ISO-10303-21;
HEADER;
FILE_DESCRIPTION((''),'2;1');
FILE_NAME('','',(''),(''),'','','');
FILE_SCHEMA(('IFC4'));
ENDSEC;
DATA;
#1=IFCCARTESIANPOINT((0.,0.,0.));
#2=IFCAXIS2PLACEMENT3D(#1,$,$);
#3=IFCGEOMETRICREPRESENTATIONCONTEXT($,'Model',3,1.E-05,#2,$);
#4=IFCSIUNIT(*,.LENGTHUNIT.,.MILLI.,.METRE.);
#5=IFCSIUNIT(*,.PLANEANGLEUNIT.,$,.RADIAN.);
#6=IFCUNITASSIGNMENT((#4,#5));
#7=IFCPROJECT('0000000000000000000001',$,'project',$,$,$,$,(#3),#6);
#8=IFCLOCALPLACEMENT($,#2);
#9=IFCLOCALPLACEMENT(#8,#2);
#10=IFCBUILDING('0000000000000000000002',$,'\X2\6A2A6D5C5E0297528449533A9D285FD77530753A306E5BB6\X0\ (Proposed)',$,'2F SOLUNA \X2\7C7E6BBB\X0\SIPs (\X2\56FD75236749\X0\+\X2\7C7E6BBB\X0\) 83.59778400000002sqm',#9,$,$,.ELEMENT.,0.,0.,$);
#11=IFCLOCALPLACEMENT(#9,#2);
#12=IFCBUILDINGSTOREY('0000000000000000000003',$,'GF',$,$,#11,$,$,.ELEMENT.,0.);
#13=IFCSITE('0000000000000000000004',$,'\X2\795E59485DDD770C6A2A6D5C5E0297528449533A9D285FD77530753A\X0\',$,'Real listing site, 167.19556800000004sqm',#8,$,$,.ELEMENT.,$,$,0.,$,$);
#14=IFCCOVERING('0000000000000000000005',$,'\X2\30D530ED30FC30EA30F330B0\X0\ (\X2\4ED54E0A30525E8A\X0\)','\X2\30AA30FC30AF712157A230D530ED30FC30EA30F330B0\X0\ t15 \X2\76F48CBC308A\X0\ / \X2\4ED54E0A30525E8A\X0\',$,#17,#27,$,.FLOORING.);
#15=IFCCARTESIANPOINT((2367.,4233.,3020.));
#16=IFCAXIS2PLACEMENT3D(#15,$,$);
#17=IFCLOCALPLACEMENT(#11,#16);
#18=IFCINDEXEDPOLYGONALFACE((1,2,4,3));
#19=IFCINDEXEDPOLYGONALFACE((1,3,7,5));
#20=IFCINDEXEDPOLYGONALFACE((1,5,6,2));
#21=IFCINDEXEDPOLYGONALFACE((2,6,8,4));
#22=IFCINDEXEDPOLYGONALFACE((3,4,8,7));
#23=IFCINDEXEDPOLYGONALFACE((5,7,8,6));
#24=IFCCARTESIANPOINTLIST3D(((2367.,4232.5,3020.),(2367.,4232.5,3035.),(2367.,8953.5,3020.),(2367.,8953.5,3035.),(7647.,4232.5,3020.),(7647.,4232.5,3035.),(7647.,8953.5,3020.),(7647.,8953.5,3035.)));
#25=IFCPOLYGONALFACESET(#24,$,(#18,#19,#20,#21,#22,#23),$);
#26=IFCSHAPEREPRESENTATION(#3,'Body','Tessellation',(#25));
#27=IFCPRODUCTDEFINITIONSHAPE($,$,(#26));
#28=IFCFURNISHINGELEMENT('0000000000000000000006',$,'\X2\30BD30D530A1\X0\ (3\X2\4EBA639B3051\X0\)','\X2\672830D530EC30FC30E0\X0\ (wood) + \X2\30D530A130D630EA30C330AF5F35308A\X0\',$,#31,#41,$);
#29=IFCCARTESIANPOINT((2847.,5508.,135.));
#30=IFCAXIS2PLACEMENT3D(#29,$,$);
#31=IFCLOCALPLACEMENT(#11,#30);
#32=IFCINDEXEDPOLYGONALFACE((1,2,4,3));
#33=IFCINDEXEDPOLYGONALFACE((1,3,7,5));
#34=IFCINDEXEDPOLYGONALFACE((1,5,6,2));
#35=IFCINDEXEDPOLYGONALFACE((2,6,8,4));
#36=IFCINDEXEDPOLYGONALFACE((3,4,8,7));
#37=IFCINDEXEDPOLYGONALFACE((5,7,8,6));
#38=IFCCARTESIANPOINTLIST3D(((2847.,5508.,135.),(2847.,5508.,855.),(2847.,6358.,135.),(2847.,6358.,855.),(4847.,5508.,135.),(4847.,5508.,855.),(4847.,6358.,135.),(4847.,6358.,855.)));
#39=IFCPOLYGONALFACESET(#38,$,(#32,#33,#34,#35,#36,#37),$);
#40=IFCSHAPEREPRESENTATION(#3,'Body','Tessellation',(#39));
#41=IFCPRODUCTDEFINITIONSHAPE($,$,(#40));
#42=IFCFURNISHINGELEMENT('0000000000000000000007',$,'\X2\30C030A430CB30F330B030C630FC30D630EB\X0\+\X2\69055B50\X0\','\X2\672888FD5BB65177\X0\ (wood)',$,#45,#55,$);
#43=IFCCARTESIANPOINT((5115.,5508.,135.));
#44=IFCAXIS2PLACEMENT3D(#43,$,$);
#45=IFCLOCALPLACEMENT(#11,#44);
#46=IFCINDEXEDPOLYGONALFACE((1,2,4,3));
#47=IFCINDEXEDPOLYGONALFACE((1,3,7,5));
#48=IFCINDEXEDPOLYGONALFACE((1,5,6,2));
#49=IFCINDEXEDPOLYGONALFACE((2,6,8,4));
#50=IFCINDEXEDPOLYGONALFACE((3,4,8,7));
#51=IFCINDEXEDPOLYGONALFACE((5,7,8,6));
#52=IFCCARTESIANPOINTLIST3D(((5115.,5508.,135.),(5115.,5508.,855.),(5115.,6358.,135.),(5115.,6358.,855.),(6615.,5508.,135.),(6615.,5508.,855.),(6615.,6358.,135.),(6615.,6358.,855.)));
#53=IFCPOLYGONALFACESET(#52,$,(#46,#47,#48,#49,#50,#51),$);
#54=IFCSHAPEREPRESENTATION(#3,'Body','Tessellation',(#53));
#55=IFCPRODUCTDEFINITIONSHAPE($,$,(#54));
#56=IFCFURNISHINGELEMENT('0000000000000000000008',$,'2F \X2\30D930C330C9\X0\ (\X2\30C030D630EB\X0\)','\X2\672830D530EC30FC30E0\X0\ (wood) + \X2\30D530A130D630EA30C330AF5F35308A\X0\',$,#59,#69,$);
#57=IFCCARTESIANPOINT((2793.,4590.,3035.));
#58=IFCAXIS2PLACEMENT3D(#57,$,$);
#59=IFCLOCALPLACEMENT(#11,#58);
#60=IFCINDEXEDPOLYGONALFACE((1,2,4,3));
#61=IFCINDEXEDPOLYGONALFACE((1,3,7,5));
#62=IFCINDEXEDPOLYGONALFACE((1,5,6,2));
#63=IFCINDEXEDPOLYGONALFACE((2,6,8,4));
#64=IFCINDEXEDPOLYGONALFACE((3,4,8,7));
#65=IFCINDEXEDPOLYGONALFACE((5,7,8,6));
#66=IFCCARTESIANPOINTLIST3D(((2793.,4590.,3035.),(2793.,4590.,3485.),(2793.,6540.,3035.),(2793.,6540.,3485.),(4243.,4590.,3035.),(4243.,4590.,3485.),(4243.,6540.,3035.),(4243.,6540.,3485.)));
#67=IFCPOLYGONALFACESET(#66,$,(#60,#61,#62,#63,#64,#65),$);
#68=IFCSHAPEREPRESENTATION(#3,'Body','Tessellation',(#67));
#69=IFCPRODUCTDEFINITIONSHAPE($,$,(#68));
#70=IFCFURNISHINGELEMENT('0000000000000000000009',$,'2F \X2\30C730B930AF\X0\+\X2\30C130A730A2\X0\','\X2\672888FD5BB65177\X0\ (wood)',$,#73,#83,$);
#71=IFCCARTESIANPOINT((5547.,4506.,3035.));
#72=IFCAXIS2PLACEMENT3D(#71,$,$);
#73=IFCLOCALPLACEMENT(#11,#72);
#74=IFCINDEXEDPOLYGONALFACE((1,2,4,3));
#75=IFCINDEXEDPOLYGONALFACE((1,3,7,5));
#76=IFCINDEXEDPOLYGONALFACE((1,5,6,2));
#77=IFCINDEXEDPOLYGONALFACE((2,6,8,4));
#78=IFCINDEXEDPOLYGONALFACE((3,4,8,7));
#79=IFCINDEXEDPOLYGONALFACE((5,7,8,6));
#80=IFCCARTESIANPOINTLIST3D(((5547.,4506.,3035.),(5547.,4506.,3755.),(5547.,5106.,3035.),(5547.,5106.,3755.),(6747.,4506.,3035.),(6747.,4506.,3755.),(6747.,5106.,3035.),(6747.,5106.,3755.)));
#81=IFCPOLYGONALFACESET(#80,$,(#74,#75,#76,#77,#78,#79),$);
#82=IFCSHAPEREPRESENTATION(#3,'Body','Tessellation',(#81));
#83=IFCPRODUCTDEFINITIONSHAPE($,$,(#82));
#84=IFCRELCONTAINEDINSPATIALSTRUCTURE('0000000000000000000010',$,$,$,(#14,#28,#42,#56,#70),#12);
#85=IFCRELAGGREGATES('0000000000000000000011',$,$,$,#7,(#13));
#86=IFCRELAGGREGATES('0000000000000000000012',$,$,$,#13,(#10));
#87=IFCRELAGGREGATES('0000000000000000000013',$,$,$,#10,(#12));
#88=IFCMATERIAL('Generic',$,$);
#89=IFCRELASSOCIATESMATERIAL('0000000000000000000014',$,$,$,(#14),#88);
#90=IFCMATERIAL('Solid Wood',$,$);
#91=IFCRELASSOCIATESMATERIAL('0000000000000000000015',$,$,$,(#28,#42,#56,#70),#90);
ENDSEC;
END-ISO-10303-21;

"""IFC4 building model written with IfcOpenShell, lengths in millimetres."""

from ifc_helpers import new_model, si_unit, frame, frame_2d, origin, place, context, project, spatial, rectangle, extrude, material, element, save


model = new_model("IFC4")

# Units and contexts
model_context = context("Model", 3, precision=1e-05, world=origin())
ifc_project = project(units=[si_unit("LENGTHUNIT", "METRE", prefix="MILLI"), si_unit("PLANEANGLEUNIT", "RADIAN")], contexts=[model_context])

# Site, building, storey
site_placement = place(None, origin())
site = spatial("IfcSite", under=ifc_project, at=site_placement, Name="神奈川県横浜市青葉区鴨志田町", ObjectType="Real listing site, 167.19556800000004sqm", CompositionType="ELEMENT", RefElevation=0.0)
building_placement = place(site_placement, origin())
building = spatial("IfcBuilding", under=site, at=building_placement, Name="横浜市青葉区鴨志田町の家 (Proposed)", ObjectType="2F SOLUNA 籾殻SIPs (国産杉+籾殻) 83.59778400000002sqm", CompositionType="ELEMENT", ElevationOfRefHeight=0.0, ElevationOfTerrain=0.0)
storey_placement = place(building_placement, origin())
storey = spatial("IfcBuildingStorey", under=building, at=storey_placement, Name="GF", CompositionType="ELEMENT", Elevation=0.0)

# Shared definitions
ifc_material_1 = material(Name="Solid Wood")

# Covering
ifc_material_2 = material(Name="Generic")
covering_placement = place(storey_placement, frame((2367.0, 4233.0, 3020.0)))
element("IfcCovering", 1, at=covering_placement, inside=storey, material=ifc_material_2, Name="フローリング (仕上げ床)", Description="オーク無垢フローリング t15 直貼り / 仕上げ床", PredefinedType="FLOORING", context=model_context, shape_type="SweptSolid", body=[
    extrude(rectangle(XDim=5280.0, YDim=4721.0, at=frame_2d((2640.0, 2360.0))), frame((2367.0, 4233.0, 3020.0)), (0.0, 0.0, 1.0), 15.0),
])

# Furnishing elements
furnishing_1_placement = place(storey_placement, frame((2847.0, 5508.0, 135.0)))
element("IfcFurnishingElement", 2, at=furnishing_1_placement, inside=storey, material=ifc_material_1, Name="ソファ (3人掛け)", Description="木フレーム (wood) + ファブリック張り", context=model_context, shape_type="SweptSolid", body=[
    extrude(rectangle(XDim=2000.0, YDim=850.0, at=frame_2d((1000.0, 425.0))), frame((2847.0, 5508.0, 135.0)), (0.0, 0.0, 1.0), 720.0),
])
furnishing_2_placement = place(storey_placement, frame((5115.0, 5508.0, 135.0)))
element("IfcFurnishingElement", 3, at=furnishing_2_placement, inside=storey, material=ifc_material_1, Name="ダイニングテーブル+椅子", Description="木製家具 (wood)", context=model_context, shape_type="SweptSolid", body=[
    extrude(rectangle(XDim=1500.0, YDim=850.0, at=frame_2d((750.0, 425.0))), frame((5115.0, 5508.0, 135.0)), (0.0, 0.0, 1.0), 720.0),
])
furnishing_3_placement = place(storey_placement, frame((2793.0, 4590.0, 3035.0)))
element("IfcFurnishingElement", 4, at=furnishing_3_placement, inside=storey, material=ifc_material_1, Name="2F ベッド (ダブル)", Description="木フレーム (wood) + ファブリック張り", context=model_context, shape_type="SweptSolid", body=[
    extrude(rectangle(XDim=1450.0, YDim=1950.0, at=frame_2d((725.0, 975.0))), frame((2793.0, 4590.0, 3035.0)), (0.0, 0.0, 1.0), 450.0),
])
furnishing_4_placement = place(storey_placement, frame((5547.0, 4506.0, 3035.0)))
element("IfcFurnishingElement", 5, at=furnishing_4_placement, inside=storey, material=ifc_material_1, Name="2F デスク+チェア", Description="木製家具 (wood)", context=model_context, shape_type="SweptSolid", body=[
    extrude(rectangle(XDim=1200.0, YDim=600.0, at=frame_2d((600.0, 300.0))), frame((5547.0, 4506.0, 3035.0)), (0.0, 0.0, 1.0), 720.0),
])

save(model, "model.ifc")
